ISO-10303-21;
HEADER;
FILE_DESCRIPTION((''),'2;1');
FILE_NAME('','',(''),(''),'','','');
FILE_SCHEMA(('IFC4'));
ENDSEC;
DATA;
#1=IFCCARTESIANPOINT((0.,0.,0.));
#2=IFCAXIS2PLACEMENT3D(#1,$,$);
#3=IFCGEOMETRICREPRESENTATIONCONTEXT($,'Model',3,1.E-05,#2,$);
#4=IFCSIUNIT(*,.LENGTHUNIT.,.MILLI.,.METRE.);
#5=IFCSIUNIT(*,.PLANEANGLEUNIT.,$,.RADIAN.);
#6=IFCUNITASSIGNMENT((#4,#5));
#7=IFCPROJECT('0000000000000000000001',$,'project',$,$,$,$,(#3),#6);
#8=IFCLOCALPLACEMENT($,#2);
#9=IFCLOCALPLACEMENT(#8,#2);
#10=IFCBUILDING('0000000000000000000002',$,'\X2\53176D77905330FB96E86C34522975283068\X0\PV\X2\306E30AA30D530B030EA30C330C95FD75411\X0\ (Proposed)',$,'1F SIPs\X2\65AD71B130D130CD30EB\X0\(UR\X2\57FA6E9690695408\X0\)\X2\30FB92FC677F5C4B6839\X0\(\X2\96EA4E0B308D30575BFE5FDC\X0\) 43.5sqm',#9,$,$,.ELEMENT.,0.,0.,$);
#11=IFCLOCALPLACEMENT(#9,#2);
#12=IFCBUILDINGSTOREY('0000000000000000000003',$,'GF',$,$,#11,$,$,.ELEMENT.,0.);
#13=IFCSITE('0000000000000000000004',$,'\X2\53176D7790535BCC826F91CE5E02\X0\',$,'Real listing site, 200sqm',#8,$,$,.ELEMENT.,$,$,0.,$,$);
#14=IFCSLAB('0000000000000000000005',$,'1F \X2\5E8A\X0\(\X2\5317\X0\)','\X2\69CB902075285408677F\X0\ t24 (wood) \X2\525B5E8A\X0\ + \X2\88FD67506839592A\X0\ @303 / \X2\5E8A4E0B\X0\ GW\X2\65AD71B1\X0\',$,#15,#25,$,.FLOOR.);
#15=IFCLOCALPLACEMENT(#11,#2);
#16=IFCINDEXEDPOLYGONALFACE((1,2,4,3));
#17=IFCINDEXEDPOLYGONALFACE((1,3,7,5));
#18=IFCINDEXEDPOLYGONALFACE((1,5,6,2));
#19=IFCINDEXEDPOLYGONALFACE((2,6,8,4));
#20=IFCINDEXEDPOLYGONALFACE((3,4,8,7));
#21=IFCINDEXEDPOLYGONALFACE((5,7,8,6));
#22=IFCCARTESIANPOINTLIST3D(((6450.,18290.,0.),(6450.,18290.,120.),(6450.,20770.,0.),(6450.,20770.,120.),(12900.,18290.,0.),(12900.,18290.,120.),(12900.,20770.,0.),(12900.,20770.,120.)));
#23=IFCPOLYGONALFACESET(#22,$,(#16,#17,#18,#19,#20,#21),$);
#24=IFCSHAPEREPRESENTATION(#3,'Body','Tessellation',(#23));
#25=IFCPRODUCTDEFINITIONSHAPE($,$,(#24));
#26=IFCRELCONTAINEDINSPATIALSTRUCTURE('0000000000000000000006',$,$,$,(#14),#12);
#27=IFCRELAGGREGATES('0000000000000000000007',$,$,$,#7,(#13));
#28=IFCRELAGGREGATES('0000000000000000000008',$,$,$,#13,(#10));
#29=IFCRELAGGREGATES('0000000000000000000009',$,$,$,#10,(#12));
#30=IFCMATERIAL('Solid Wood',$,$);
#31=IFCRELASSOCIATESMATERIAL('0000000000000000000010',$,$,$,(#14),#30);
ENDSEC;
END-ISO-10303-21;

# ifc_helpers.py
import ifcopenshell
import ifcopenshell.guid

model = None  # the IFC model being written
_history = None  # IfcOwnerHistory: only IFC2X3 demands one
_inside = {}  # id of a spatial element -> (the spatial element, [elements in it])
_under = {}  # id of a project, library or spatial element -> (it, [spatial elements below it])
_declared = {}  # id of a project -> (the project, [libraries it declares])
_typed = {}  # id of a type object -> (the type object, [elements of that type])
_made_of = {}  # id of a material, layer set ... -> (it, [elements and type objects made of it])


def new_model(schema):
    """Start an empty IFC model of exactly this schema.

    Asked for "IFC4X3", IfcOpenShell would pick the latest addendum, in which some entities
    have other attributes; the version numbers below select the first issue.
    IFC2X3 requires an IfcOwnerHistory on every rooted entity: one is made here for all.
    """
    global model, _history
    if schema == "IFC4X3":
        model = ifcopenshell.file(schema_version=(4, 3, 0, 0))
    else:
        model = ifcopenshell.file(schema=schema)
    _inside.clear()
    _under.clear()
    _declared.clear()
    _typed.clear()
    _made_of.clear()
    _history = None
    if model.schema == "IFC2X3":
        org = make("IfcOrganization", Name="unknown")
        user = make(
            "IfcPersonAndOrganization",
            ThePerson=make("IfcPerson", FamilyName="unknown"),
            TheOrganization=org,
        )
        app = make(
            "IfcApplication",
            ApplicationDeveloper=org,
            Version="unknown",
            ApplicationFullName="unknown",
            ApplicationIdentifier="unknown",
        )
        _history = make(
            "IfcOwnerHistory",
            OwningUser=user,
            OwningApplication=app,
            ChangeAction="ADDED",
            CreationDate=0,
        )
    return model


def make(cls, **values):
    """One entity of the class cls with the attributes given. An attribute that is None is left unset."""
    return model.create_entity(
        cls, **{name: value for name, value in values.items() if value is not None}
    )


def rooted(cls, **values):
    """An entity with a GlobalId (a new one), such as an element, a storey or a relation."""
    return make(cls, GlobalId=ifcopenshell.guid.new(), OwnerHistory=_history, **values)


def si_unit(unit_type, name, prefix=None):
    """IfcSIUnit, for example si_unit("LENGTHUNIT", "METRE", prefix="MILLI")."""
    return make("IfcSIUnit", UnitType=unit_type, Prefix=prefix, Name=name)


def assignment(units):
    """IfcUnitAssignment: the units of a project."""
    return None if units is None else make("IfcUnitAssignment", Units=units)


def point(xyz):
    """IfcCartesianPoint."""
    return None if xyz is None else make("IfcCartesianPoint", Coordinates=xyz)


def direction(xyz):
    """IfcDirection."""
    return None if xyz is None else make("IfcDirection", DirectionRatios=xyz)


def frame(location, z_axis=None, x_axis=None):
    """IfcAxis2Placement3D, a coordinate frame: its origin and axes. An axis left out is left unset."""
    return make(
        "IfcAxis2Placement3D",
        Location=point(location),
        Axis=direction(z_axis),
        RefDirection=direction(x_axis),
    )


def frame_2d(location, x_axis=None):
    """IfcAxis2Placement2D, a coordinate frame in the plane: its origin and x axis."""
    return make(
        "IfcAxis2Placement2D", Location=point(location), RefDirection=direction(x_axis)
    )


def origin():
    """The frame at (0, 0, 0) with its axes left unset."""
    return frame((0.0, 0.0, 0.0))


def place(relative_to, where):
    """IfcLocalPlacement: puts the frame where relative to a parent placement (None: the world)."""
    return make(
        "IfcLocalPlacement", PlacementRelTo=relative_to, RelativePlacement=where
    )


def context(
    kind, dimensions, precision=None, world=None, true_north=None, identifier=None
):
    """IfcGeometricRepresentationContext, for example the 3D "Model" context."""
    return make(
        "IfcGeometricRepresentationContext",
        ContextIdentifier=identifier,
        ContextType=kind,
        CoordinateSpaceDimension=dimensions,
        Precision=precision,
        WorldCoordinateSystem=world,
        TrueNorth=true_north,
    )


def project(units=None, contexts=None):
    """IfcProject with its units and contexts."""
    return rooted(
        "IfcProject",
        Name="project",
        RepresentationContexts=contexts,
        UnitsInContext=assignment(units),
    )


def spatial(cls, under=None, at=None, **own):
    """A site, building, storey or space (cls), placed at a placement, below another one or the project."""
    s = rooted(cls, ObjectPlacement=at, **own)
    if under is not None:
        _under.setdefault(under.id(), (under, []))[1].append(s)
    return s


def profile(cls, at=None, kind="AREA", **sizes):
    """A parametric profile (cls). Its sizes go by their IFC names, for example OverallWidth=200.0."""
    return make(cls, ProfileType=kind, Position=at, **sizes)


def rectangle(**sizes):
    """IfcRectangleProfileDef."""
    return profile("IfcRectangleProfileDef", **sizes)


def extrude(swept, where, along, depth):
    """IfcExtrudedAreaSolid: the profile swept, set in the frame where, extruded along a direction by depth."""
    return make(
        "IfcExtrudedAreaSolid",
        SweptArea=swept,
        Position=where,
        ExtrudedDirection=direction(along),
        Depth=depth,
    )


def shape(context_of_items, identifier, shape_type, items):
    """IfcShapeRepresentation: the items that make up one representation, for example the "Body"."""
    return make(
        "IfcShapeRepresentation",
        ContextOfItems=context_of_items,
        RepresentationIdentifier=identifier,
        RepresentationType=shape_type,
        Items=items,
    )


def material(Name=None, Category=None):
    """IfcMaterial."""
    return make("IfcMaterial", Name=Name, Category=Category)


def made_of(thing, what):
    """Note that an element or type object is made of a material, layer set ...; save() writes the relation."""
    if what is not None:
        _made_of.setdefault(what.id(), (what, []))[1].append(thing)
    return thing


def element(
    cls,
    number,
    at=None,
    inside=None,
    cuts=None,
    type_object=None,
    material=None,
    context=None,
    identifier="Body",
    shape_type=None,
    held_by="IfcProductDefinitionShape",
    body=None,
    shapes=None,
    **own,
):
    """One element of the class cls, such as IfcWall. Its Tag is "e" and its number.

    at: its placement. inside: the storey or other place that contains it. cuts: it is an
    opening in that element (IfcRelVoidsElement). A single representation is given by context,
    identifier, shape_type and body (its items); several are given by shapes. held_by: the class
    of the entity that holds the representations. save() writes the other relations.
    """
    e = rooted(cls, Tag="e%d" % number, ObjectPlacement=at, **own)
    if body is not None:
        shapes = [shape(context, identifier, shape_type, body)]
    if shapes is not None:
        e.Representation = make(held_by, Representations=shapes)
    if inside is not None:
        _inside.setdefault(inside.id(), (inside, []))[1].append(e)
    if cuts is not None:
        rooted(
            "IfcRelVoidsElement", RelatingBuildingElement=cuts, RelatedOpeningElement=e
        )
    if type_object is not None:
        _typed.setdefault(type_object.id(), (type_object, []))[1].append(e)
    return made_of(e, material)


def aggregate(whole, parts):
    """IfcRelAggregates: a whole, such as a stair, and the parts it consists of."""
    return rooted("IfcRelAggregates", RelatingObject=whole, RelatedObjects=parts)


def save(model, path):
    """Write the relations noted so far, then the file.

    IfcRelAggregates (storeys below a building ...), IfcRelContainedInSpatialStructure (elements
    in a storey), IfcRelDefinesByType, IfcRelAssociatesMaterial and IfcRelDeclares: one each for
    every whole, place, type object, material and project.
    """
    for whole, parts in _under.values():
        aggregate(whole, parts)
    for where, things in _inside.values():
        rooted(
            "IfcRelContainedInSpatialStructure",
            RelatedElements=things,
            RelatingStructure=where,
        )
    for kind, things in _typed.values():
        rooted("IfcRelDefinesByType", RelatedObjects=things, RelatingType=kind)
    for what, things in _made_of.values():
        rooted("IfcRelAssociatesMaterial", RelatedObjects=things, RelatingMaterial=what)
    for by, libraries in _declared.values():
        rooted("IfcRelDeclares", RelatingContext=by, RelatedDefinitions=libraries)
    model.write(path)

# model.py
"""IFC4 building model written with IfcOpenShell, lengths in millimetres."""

from ifc_helpers import new_model, si_unit, frame, frame_2d, origin, place, context, project, spatial, rectangle, extrude, material, element, save


model = new_model("IFC4")

# Units and contexts
model_context = context("Model", 3, precision=1e-05, world=origin())
ifc_project = project(units=[si_unit("LENGTHUNIT", "METRE", prefix="MILLI"), si_unit("PLANEANGLEUNIT", "RADIAN")], contexts=[model_context])

# Site, building, storey
site_placement = place(None, origin())
site = spatial("IfcSite", under=ifc_project, at=site_placement, Name="北海道富良野市", ObjectType="Real listing site, 200sqm", CompositionType="ELEMENT", RefElevation=0.0)
building_placement = place(site_placement, origin())
building = spatial("IfcBuilding", under=site, at=building_placement, Name="北海道・雨水利用とPVのオフグリッド志向 (Proposed)", ObjectType="1F SIPs断熱パネル(UR基準適合)・鋼板屋根(雪下ろし対応) 43.5sqm", CompositionType="ELEMENT", ElevationOfRefHeight=0.0, ElevationOfTerrain=0.0)
storey_placement = place(building_placement, origin())
storey = spatial("IfcBuildingStorey", under=building, at=storey_placement, Name="GF", CompositionType="ELEMENT", Elevation=0.0)

# Shared definitions
ifc_material_1 = material(Name="Solid Wood")

# Slab
slab_1_placement = place(storey_placement, frame((3225.0, 9145.0, 0.0)))
element("IfcSlab", 1, at=slab_1_placement, inside=storey, material=ifc_material_1, Name="1F 床(北)", Description="構造用合板 t24 (wood) 剛床 + 製材根太 @303 / 床下 GW断熱", PredefinedType="FLOOR", context=model_context, shape_type="SweptSolid", body=[
    extrude(rectangle(XDim=6450.0, YDim=2480.0, at=frame_2d((3225.0, 1240.0))), frame((3225.0, 9145.0, 0.0)), (0.0, 0.0, 1.0), 120.0),
])

save(model, "model.ifc")
